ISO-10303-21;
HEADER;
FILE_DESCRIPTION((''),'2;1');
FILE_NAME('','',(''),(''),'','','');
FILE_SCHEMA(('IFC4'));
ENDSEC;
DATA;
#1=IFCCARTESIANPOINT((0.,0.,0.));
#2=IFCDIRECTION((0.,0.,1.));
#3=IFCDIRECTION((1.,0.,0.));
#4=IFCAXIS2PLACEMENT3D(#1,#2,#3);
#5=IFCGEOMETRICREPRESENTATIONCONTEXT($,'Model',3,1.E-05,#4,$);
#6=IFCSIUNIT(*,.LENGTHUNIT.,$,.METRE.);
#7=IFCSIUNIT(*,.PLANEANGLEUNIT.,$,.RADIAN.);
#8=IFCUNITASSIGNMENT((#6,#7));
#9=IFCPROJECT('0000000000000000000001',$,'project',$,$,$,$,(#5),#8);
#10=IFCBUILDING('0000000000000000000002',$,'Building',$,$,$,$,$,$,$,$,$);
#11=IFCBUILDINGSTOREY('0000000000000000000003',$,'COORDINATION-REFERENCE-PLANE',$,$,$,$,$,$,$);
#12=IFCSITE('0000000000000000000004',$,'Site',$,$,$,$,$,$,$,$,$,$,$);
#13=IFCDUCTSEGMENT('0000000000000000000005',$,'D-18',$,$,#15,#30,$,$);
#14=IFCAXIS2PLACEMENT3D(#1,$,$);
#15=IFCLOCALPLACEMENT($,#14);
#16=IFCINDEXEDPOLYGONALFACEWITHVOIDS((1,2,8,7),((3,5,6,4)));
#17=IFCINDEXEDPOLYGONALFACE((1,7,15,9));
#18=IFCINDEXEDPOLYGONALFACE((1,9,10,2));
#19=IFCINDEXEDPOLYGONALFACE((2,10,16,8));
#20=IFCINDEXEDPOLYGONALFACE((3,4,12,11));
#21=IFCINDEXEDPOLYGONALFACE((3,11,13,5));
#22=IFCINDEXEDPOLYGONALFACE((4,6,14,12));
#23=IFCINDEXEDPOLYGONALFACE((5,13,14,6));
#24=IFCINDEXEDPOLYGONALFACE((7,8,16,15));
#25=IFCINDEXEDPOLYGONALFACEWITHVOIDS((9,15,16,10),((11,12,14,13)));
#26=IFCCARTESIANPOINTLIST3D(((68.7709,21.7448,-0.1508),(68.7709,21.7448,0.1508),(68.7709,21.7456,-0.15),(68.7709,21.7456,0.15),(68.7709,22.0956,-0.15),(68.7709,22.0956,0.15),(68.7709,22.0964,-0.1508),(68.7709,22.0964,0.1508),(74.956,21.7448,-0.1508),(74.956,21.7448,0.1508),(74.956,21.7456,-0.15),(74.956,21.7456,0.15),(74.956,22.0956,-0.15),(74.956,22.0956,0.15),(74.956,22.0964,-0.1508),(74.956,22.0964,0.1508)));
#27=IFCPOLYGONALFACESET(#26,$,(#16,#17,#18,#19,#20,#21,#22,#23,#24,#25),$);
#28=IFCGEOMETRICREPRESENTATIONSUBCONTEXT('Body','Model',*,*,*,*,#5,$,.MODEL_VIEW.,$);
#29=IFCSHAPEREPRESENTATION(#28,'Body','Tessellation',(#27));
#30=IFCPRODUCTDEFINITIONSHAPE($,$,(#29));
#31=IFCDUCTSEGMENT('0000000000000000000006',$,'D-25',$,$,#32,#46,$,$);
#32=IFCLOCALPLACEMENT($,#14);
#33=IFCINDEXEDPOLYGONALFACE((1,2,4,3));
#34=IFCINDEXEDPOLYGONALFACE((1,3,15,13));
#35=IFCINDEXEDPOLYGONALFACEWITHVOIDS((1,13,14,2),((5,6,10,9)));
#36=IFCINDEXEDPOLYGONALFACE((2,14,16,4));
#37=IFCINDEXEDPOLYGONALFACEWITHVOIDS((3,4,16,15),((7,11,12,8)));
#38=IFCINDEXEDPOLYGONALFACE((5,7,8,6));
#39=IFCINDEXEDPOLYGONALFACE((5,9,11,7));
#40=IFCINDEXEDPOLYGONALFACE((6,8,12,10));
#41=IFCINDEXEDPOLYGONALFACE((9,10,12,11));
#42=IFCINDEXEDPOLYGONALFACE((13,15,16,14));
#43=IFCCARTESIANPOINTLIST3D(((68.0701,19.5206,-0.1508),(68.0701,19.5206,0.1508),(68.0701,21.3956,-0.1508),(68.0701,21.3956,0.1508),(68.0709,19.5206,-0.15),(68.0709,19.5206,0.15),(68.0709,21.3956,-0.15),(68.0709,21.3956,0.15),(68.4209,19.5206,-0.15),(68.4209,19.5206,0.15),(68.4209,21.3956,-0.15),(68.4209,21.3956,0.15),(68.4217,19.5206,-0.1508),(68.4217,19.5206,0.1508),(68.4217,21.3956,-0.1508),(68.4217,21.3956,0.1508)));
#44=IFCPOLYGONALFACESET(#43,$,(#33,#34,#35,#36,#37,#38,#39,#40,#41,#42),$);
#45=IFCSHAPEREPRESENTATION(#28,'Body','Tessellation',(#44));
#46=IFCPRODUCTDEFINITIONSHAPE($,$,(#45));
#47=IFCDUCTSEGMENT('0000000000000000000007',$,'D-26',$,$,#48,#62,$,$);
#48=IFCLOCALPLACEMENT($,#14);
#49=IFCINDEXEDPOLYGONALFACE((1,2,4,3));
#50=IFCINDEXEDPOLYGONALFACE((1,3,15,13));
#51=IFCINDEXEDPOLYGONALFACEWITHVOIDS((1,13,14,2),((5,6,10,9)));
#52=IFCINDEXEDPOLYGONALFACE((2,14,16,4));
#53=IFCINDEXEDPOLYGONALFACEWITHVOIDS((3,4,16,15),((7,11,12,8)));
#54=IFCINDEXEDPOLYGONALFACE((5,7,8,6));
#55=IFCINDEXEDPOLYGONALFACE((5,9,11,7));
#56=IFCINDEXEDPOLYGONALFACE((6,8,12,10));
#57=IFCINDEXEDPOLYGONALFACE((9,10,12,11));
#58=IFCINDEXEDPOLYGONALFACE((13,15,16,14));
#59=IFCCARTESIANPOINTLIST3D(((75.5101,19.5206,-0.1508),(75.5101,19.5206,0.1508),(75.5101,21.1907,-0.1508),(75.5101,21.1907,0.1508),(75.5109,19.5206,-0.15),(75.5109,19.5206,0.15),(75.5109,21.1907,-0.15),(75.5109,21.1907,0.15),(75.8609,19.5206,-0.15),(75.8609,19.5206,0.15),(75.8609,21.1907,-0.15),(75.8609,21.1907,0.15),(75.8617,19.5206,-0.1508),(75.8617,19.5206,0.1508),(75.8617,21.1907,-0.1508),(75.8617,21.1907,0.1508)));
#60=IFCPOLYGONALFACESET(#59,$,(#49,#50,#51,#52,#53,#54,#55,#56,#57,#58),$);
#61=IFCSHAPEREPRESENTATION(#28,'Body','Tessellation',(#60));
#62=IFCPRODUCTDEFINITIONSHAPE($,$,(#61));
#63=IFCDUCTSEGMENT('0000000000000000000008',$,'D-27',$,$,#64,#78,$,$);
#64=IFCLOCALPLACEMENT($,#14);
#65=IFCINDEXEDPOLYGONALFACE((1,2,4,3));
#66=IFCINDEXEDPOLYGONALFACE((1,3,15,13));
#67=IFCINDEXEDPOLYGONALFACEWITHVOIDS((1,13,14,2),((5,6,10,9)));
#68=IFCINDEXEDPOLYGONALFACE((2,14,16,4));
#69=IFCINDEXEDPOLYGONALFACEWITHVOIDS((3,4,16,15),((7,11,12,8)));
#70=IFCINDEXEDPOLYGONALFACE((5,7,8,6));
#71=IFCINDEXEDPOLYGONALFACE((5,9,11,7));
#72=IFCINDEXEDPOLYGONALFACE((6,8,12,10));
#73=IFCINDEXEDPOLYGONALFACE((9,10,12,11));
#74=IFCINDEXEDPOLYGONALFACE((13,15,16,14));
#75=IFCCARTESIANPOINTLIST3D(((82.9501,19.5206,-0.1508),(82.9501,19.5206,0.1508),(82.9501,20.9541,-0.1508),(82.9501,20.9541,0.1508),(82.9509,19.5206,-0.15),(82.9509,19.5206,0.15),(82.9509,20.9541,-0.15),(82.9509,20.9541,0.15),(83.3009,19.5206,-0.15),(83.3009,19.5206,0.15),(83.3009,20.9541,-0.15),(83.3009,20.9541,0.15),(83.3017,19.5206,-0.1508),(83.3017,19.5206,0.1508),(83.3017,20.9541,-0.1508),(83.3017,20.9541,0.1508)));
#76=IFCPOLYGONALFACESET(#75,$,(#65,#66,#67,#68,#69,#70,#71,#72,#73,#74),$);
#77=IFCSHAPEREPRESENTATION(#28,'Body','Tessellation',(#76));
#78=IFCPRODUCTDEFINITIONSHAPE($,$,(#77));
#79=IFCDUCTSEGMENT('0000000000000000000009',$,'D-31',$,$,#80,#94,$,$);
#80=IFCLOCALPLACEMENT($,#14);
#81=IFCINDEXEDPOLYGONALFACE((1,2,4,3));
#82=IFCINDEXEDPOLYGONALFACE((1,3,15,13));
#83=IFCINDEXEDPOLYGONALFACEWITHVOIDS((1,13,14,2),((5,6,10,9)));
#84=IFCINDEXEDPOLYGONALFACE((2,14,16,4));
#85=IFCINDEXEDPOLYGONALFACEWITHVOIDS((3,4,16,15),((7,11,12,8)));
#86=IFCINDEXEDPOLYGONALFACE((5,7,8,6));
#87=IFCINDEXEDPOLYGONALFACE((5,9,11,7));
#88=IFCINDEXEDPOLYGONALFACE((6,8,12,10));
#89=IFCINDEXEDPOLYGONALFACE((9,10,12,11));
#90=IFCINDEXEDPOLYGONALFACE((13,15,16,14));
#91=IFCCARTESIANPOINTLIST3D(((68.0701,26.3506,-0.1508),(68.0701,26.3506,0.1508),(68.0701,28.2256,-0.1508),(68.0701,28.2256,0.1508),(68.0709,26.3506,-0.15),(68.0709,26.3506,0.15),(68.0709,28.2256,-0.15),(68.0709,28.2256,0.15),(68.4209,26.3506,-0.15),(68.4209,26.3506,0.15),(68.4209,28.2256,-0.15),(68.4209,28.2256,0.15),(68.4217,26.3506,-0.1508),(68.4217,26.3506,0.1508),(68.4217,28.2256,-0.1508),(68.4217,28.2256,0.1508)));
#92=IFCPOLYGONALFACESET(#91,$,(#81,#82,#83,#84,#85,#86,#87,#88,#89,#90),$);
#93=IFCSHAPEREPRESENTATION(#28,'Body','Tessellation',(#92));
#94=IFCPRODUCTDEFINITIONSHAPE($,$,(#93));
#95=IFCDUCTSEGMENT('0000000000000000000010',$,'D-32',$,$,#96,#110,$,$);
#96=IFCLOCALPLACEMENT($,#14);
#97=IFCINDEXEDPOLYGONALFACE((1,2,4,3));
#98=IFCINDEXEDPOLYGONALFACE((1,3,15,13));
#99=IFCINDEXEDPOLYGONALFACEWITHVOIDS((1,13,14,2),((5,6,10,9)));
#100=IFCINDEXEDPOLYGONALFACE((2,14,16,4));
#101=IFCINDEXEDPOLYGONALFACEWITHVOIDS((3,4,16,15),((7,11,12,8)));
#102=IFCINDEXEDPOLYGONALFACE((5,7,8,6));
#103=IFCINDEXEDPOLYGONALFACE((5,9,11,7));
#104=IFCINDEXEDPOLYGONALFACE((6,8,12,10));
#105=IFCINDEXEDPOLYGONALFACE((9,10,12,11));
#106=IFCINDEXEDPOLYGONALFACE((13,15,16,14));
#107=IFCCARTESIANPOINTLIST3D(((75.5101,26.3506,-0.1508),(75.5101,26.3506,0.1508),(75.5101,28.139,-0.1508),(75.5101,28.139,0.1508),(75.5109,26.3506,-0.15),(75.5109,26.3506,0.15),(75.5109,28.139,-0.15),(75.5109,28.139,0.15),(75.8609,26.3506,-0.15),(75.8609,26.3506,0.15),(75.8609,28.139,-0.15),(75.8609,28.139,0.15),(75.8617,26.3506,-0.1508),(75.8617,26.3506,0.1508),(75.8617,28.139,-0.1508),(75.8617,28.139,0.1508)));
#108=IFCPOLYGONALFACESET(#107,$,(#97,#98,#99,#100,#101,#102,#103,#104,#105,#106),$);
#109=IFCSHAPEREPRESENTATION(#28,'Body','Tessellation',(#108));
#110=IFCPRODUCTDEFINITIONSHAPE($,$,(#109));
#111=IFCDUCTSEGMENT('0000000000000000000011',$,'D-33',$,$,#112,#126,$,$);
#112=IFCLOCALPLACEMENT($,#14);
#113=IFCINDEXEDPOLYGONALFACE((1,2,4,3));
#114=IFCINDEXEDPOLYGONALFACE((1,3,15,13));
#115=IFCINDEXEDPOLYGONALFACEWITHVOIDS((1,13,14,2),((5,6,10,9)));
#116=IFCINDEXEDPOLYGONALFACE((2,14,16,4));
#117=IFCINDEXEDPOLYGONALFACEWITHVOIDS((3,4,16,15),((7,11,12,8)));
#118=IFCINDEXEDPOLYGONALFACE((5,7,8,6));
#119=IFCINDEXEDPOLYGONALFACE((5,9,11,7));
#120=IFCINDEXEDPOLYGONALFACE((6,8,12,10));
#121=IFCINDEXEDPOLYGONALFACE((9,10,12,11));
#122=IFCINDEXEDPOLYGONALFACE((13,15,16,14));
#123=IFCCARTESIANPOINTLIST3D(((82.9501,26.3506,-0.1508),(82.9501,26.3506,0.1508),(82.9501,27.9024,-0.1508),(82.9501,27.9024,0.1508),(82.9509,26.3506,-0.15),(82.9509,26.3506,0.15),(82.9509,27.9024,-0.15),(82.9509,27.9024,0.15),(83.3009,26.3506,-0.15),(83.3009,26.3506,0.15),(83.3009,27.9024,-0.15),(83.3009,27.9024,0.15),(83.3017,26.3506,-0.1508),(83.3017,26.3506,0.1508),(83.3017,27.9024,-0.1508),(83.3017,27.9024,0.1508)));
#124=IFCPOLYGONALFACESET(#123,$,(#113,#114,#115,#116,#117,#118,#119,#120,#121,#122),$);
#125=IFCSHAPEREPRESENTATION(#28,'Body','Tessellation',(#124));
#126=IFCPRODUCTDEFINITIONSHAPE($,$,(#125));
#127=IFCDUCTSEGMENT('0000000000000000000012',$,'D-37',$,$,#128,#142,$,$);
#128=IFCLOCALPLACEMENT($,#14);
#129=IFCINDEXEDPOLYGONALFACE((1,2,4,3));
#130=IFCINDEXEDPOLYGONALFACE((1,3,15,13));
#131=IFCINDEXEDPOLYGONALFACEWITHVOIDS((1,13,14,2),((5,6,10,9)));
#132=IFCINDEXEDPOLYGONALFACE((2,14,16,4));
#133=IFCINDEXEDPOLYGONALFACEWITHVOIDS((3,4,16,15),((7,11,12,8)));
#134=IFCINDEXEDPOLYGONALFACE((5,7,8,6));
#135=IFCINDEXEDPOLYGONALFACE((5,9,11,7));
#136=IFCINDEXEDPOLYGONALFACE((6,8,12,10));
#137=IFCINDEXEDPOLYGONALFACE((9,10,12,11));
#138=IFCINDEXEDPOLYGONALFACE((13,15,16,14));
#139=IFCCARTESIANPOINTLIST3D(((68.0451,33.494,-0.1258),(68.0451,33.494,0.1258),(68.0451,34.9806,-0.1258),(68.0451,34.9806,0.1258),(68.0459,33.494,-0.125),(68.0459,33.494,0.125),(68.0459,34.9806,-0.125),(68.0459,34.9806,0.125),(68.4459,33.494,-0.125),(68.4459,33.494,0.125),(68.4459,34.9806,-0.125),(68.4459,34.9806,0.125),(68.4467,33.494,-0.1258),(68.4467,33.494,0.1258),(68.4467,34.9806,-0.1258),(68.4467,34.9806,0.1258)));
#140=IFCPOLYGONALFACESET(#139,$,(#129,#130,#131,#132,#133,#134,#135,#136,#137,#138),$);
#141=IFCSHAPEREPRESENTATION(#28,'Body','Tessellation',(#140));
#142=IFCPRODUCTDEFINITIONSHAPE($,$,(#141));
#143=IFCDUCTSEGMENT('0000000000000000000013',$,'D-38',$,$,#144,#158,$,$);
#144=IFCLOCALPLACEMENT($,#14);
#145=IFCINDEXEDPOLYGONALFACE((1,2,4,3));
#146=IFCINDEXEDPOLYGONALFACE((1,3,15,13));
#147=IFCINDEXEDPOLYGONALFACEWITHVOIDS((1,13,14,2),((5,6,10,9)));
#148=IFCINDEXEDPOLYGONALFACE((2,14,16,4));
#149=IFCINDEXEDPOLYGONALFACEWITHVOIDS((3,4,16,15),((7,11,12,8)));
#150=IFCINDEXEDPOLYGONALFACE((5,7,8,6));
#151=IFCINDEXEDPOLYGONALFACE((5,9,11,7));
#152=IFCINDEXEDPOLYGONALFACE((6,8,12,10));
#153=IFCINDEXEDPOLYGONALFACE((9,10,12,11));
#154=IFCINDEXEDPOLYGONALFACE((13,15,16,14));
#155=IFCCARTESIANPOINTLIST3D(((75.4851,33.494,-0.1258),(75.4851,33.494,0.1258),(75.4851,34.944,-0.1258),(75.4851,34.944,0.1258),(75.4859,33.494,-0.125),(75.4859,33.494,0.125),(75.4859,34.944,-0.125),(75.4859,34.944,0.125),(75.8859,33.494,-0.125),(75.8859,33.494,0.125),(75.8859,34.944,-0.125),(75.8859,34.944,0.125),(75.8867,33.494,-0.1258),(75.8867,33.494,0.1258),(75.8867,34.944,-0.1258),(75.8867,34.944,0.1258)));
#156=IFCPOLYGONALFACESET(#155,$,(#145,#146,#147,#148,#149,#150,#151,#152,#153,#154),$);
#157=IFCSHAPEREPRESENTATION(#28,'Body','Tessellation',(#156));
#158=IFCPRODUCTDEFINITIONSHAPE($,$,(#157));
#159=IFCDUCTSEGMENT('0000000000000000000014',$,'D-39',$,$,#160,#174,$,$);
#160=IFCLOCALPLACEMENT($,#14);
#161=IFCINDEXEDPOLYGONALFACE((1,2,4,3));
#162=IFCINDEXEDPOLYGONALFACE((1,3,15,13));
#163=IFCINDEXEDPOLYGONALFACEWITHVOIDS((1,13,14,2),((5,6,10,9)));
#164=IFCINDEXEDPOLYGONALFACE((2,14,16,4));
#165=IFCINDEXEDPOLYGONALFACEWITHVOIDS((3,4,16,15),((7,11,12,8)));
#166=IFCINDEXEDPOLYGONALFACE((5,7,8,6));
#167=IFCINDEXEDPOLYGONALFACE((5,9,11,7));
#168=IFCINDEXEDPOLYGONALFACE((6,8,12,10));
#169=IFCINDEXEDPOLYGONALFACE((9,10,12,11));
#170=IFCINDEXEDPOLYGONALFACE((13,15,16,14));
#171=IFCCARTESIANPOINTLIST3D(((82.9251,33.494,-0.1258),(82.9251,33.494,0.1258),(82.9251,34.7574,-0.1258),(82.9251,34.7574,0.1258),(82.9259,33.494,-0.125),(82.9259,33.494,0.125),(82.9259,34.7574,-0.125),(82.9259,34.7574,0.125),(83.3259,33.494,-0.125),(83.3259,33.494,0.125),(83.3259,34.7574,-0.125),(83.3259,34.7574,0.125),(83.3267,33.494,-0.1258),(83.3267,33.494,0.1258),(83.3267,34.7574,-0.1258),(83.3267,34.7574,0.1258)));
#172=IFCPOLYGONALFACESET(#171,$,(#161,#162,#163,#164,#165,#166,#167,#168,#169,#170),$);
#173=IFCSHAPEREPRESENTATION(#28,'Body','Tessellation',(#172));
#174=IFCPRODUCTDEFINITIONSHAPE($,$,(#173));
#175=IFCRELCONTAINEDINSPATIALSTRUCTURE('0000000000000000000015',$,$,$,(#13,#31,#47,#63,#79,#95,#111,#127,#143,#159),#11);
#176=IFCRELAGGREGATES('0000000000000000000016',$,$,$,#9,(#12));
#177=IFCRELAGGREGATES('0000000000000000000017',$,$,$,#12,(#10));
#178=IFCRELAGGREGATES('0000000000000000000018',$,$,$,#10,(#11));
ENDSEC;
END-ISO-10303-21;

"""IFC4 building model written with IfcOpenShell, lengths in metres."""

from ifc_helpers import new_model, si_unit, frame, origin, origin_with_axes, place, context, subcontext, project, spatial, hollow_rectangle, extrude, element, save


model = new_model("IFC4")

# Units and contexts
model_context = context("Model", 3, precision=1e-05, world=origin_with_axes())
body_context = subcontext(model_context, "Body", "Model", "MODEL_VIEW")
ifc_project = project(units=[si_unit("LENGTHUNIT", "METRE"), si_unit("PLANEANGLEUNIT", "RADIAN")], contexts=[model_context])

# Site, building, storey
site = spatial("IfcSite", under=ifc_project, Name="Site")
building = spatial("IfcBuilding", under=site, Name="Building")
storey = spatial("IfcBuildingStorey", under=building, Name="COORDINATION-REFERENCE-PLANE")

# Duct segments
duct_segment_1_placement = place(None, frame((68.7709, 21.9206, 0.0), z_axis=(1.0, 0.0, 0.0), x_axis=(0.0, 1.0, 0.0)))
element("IfcDuctSegment", 1, at=duct_segment_1_placement, inside=storey, Name="D-18", context=body_context, shape_type="SweptSolid", body=[
    extrude(hollow_rectangle(XDim=0.3516, YDim=0.3016, WallThickness=0.0008), origin(), (0.0, 0.0, 1.0), 6.1851),
])
duct_segment_2_placement = place(None, frame((68.2459, 19.5206, 0.0), z_axis=(0.0, 1.0, 0.0), x_axis=(1.0, 0.0, 0.0)))
element("IfcDuctSegment", 2, at=duct_segment_2_placement, inside=storey, Name="D-25", context=body_context, shape_type="SweptSolid", body=[
    extrude(hollow_rectangle(XDim=0.3516, YDim=0.3016, WallThickness=0.0008), origin(), (0.0, 0.0, 1.0), 1.875),
])
duct_segment_3_placement = place(None, frame((75.6859, 19.5206, 0.0), z_axis=(0.0, 1.0, 0.0), x_axis=(1.0, 0.0, 0.0)))
element("IfcDuctSegment", 3, at=duct_segment_3_placement, inside=storey, Name="D-26", context=body_context, shape_type="SweptSolid", body=[
    extrude(hollow_rectangle(XDim=0.3516, YDim=0.3016, WallThickness=0.0008), origin(), (0.0, 0.0, 1.0), 1.6701),
])
duct_segment_4_placement = place(None, frame((83.1259, 19.5206, 0.0), z_axis=(0.0, 1.0, 0.0), x_axis=(1.0, 0.0, 0.0)))
element("IfcDuctSegment", 4, at=duct_segment_4_placement, inside=storey, Name="D-27", context=body_context, shape_type="SweptSolid", body=[
    extrude(hollow_rectangle(XDim=0.3516, YDim=0.3016, WallThickness=0.0008), origin(), (0.0, 0.0, 1.0), 1.4335),
])
duct_segment_5_placement = place(None, frame((68.2459, 26.3506, 0.0), z_axis=(0.0, 1.0, 0.0), x_axis=(1.0, 0.0, 0.0)))
element("IfcDuctSegment", 5, at=duct_segment_5_placement, inside=storey, Name="D-31", context=body_context, shape_type="SweptSolid", body=[
    extrude(hollow_rectangle(XDim=0.3516, YDim=0.3016, WallThickness=0.0008), origin(), (0.0, 0.0, 1.0), 1.875),
])
duct_segment_6_placement = place(None, frame((75.6859, 26.3506, 0.0), z_axis=(0.0, 1.0, 0.0), x_axis=(1.0, 0.0, 0.0)))
element("IfcDuctSegment", 6, at=duct_segment_6_placement, inside=storey, Name="D-32", context=body_context, shape_type="SweptSolid", body=[
    extrude(hollow_rectangle(XDim=0.3516, YDim=0.3016, WallThickness=0.0008), origin(), (0.0, 0.0, 1.0), 1.7884),
])
duct_segment_7_placement = place(None, frame((83.1259, 26.3506, 0.0), z_axis=(0.0, 1.0, 0.0), x_axis=(1.0, 0.0, 0.0)))
element("IfcDuctSegment", 7, at=duct_segment_7_placement, inside=storey, Name="D-33", context=body_context, shape_type="SweptSolid", body=[
    extrude(hollow_rectangle(XDim=0.3516, YDim=0.3016, WallThickness=0.0008), origin(), (0.0, 0.0, 1.0), 1.5518),
])
duct_segment_8_placement = place(None, frame((68.2459, 33.494, 0.0), z_axis=(0.0, 1.0, 0.0), x_axis=(1.0, 0.0, 0.0)))
element("IfcDuctSegment", 8, at=duct_segment_8_placement, inside=storey, Name="D-37", context=body_context, shape_type="SweptSolid", body=[
    extrude(hollow_rectangle(XDim=0.4016, YDim=0.2516, WallThickness=0.0008), origin(), (0.0, 0.0, 1.0), 1.4865),
])
duct_segment_9_placement = place(None, frame((75.6859, 33.494, 0.0), z_axis=(0.0, 1.0, 0.0), x_axis=(1.0, 0.0, 0.0)))
element("IfcDuctSegment", 9, at=duct_segment_9_placement, inside=storey, Name="D-38", context=body_context, shape_type="SweptSolid", body=[
    extrude(hollow_rectangle(XDim=0.4016, YDim=0.2516, WallThickness=0.0008), origin(), (0.0, 0.0, 1.0), 1.4499),
])
duct_segment_10_placement = place(None, frame((83.1259, 33.494, 0.0), z_axis=(0.0, 1.0, 0.0), x_axis=(1.0, 0.0, 0.0)))
element("IfcDuctSegment", 10, at=duct_segment_10_placement, inside=storey, Name="D-39", context=body_context, shape_type="SweptSolid", body=[
    extrude(hollow_rectangle(XDim=0.4016, YDim=0.2516, WallThickness=0.0008), origin(), (0.0, 0.0, 1.0), 1.2633),
])

save(model, "model.ifc")
